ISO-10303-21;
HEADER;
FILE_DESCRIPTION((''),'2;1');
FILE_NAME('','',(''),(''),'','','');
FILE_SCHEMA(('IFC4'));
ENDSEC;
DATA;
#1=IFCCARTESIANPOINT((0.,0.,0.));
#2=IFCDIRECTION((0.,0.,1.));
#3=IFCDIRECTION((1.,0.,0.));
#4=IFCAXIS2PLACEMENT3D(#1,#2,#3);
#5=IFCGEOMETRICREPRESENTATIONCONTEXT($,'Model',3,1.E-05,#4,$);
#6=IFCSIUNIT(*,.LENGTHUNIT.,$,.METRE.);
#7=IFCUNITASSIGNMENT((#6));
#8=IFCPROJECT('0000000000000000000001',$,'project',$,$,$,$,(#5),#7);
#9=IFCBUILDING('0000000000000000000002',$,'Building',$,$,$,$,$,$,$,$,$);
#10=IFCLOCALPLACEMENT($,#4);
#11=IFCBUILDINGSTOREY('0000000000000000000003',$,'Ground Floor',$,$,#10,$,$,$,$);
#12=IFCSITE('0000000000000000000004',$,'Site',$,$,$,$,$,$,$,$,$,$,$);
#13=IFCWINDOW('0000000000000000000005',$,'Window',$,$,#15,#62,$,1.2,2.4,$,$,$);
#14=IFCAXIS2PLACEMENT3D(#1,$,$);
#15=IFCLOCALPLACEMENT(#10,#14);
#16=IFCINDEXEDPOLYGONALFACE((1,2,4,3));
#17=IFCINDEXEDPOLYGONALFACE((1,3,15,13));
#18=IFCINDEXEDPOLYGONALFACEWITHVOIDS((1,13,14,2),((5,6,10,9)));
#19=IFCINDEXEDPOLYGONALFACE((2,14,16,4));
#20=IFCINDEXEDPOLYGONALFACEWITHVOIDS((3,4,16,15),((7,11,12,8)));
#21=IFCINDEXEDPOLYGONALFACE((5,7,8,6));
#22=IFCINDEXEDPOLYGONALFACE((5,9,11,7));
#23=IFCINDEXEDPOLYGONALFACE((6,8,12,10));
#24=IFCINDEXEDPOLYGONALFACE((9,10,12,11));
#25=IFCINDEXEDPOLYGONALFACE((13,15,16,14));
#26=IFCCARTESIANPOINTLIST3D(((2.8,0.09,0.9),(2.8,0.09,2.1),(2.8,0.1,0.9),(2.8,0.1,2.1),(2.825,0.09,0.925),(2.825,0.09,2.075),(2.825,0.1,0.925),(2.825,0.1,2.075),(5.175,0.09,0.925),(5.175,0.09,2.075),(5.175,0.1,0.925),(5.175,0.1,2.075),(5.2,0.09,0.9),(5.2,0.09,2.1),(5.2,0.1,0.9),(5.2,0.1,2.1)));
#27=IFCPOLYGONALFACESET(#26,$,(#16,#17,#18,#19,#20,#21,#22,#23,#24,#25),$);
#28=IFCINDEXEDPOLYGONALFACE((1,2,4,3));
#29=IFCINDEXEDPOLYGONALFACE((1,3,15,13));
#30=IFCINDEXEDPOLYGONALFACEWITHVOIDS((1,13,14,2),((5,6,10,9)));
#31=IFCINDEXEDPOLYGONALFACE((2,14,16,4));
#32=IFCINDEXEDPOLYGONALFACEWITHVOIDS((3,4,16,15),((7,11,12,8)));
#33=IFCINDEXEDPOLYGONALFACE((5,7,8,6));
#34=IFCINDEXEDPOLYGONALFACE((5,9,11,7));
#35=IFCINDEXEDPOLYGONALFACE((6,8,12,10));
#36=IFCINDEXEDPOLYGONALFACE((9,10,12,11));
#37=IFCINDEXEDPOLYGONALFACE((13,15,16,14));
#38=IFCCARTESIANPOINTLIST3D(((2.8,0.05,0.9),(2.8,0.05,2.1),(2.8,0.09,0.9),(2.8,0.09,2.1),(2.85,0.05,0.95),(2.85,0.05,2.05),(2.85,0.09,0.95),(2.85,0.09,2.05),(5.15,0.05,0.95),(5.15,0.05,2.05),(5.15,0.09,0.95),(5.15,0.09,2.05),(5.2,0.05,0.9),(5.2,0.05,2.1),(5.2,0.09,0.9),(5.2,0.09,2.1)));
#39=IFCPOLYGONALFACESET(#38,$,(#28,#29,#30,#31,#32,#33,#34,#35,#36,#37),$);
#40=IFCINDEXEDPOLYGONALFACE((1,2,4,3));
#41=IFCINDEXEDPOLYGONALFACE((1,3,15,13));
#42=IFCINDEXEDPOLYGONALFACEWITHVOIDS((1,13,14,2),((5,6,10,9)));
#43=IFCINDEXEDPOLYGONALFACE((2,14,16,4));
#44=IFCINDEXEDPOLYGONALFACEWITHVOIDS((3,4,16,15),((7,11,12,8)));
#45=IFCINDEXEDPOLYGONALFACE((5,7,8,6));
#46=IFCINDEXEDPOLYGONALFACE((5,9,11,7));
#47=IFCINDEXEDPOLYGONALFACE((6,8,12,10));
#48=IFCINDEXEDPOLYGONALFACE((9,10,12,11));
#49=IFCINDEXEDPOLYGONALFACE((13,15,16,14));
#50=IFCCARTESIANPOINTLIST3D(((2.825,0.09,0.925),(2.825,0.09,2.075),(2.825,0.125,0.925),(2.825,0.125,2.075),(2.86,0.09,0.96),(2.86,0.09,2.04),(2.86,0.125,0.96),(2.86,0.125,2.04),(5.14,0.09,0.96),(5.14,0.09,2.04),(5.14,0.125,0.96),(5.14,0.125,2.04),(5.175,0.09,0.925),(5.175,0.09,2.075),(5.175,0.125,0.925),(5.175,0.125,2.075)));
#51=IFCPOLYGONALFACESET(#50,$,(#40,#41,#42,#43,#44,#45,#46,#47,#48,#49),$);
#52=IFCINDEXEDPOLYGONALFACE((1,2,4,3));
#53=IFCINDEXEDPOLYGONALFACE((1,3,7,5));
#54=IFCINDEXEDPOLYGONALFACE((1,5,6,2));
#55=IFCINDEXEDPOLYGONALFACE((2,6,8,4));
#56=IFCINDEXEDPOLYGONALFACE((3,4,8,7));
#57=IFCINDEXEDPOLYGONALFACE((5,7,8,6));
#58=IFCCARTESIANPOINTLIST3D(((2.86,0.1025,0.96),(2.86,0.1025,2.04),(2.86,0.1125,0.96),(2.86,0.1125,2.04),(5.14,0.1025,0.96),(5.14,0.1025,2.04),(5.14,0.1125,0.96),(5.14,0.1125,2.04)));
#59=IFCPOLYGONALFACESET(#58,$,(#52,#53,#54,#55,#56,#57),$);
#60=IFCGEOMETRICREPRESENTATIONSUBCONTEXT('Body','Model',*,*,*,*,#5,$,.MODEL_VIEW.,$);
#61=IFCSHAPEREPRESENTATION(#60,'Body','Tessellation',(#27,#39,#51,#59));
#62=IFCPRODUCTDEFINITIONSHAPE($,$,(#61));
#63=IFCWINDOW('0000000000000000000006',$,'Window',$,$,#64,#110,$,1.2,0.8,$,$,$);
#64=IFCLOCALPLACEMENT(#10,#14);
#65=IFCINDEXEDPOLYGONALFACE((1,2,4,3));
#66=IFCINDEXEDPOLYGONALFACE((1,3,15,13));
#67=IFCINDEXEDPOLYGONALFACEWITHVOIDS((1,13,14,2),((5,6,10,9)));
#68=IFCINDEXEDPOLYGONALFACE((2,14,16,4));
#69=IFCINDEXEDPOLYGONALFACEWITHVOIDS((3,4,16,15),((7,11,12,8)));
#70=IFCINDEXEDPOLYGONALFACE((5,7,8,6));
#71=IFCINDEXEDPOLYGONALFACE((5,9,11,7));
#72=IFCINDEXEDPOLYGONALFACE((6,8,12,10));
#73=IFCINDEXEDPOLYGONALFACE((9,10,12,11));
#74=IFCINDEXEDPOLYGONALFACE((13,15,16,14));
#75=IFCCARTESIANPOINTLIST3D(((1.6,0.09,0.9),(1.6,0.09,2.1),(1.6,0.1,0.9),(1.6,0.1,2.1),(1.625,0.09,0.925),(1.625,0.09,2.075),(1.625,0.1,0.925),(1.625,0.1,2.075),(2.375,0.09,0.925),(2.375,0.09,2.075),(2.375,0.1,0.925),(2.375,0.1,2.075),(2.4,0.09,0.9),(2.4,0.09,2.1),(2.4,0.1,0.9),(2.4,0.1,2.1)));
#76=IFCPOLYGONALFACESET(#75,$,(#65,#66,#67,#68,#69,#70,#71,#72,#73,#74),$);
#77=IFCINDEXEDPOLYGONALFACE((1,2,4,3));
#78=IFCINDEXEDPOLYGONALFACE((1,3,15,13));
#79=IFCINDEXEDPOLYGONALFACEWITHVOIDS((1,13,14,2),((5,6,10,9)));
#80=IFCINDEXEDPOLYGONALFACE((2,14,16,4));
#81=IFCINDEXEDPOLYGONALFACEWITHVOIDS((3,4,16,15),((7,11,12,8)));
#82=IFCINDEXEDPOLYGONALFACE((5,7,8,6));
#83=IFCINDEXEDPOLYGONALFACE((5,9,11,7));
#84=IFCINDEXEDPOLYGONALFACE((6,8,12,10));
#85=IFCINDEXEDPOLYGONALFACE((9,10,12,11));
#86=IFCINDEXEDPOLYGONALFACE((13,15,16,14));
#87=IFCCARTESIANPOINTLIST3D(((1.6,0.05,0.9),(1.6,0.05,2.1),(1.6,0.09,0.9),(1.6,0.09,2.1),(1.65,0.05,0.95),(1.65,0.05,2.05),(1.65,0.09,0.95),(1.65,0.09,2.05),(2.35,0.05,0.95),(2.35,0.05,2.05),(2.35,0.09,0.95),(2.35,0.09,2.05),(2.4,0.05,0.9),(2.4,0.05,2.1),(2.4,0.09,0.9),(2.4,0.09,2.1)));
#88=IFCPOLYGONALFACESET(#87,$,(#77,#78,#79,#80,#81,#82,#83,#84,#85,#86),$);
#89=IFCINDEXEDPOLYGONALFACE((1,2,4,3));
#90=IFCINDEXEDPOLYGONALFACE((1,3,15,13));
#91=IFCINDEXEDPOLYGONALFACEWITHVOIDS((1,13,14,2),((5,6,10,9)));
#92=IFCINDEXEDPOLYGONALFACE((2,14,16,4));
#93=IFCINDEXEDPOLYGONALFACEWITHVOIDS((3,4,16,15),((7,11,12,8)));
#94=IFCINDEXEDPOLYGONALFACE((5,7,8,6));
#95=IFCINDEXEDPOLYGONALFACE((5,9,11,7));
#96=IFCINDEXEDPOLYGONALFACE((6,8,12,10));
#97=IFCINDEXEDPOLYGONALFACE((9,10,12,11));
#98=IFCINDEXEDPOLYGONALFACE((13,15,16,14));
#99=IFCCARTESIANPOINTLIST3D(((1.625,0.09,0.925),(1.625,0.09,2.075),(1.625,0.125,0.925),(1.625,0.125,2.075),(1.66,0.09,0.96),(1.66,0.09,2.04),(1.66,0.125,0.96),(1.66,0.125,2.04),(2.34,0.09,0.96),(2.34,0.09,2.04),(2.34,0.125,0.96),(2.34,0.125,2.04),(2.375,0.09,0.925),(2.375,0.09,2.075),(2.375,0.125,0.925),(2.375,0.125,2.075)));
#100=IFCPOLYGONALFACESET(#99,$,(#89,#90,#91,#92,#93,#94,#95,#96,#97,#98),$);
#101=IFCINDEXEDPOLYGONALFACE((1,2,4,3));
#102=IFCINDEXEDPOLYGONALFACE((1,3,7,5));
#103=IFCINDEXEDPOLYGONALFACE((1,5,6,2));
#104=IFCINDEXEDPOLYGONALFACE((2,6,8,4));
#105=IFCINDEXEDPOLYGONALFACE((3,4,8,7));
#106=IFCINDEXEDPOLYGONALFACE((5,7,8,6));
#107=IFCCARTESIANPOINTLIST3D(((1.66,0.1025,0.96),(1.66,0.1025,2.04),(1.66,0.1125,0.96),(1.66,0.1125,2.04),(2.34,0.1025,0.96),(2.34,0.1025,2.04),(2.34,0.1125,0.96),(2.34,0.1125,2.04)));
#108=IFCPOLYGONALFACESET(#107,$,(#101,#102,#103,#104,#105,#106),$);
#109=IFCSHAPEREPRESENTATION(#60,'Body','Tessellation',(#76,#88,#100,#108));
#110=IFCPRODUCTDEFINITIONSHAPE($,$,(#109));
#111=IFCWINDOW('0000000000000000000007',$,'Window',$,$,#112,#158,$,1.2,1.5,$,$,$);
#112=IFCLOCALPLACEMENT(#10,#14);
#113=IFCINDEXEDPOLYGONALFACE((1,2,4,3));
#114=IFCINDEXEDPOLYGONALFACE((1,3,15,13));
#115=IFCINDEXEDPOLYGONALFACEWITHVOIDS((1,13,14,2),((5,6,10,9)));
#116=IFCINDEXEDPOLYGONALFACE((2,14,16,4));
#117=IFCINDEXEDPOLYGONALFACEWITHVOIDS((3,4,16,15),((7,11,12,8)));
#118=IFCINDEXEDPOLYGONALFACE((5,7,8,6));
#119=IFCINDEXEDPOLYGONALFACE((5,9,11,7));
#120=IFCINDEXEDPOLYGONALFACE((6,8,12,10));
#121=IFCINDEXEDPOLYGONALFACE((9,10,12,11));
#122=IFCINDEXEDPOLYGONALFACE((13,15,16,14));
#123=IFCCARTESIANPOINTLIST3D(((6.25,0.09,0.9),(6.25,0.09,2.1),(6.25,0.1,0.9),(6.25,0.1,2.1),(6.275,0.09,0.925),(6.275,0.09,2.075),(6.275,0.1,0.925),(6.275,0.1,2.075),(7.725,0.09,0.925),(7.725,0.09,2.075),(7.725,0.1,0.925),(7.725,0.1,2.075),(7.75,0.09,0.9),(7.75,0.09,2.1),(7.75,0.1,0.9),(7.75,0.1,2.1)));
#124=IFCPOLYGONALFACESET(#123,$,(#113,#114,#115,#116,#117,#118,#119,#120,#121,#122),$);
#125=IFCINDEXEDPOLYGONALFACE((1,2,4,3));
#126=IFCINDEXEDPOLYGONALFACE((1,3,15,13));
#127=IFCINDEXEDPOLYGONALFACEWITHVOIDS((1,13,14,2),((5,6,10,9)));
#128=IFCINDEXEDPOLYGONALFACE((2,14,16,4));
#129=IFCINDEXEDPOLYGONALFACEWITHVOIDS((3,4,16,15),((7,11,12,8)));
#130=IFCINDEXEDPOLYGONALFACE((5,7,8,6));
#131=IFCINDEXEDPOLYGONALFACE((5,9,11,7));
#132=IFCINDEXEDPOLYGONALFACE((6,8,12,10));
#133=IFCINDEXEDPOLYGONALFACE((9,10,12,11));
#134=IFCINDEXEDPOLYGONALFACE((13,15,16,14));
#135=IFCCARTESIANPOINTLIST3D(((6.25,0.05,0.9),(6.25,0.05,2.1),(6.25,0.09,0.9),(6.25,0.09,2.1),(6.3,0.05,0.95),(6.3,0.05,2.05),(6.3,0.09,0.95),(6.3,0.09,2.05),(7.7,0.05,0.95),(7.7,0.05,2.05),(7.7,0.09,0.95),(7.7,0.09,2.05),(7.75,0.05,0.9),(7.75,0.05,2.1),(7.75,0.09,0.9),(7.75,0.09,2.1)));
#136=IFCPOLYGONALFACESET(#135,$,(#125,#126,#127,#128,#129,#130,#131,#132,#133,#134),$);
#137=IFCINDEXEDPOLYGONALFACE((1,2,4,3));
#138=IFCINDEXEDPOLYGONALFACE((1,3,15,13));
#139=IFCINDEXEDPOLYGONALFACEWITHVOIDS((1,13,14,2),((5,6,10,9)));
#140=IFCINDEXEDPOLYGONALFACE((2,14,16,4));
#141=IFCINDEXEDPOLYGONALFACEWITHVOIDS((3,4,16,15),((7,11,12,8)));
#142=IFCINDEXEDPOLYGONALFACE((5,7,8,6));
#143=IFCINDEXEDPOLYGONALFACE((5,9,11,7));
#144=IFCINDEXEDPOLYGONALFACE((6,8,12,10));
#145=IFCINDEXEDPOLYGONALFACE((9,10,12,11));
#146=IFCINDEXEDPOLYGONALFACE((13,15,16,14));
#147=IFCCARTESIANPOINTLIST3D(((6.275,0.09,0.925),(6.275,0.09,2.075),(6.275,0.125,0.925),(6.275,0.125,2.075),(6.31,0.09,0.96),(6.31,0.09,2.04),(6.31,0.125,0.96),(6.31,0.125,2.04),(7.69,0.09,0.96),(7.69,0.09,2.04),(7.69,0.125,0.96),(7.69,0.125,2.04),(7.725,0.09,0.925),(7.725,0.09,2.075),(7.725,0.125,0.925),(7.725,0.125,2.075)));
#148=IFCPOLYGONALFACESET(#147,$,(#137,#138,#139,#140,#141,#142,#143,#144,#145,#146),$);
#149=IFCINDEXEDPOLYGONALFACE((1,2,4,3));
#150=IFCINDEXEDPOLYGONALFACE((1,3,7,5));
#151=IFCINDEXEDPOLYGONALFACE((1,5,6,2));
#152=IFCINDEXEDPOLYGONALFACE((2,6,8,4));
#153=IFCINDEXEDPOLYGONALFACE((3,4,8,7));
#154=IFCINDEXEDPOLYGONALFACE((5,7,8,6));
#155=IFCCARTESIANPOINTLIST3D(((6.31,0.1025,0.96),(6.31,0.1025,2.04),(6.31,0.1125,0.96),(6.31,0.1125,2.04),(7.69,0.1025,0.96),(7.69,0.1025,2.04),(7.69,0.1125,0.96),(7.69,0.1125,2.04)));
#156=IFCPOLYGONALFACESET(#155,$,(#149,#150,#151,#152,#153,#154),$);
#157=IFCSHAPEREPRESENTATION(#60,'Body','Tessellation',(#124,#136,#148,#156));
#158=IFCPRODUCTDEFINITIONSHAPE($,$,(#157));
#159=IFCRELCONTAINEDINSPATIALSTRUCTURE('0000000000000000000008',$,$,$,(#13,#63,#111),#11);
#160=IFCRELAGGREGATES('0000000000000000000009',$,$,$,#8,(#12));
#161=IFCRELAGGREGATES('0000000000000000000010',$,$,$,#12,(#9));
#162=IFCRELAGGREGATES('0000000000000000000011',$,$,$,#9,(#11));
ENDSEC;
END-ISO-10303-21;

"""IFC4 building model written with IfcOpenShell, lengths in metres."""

from ifc_helpers import new_model, si_unit, frame, origin_with_axes, place, context, subcontext, project, spatial, line, indexed_curve, outline, extrude, element, save


model = new_model("IFC4")

# Units and contexts
model_context = context("Model", 3, precision=1e-05, world=origin_with_axes())
body_context = subcontext(model_context, "Body", "Model", "MODEL_VIEW")
ifc_project = project(units=[si_unit("LENGTHUNIT", "METRE")], contexts=[model_context])

# Site, building, storey
site = spatial("IfcSite", under=ifc_project, Name="Site")
building = spatial("IfcBuilding", under=site, Name="Building")
storey_placement = place(None, origin_with_axes())
storey = spatial("IfcBuildingStorey", under=building, at=storey_placement, Name="Ground Floor")

# Windows
window_1_placement = place(storey_placement, frame((2.8, 0.0, 0.9), z_axis=(0.0, 0.0, 1.0), x_axis=(1.0, 0.0, 0.0)))
element("IfcWindow", 1, at=window_1_placement, inside=storey, Name="Window", OverallHeight=1.2, OverallWidth=2.4, context=body_context, shape_type="SweptSolid", body=[
    extrude(outline(indexed_curve([(0.0, 0.0), (2.4, 0.0), (2.4, 1.2), (0.0, 1.2)], segments=[line(1, 2, 3, 4, 1)]), holes=[indexed_curve([(0.025, 0.025), (2.375, 0.025), (2.375, 1.175), (0.025, 1.175)], segments=[line(1, 2, 3, 4, 1)])]), frame((0.0, 0.09, 0.0), z_axis=(0.0, -1.0, 0.0), x_axis=(1.0, 0.0, 0.0)), (0.0, 0.0, -1.0), 0.01),
    extrude(outline(indexed_curve([(0.0, 0.0), (2.4, 0.0), (2.4, 1.2), (0.0, 1.2)], segments=[line(1, 2, 3, 4, 1)]), holes=[indexed_curve([(0.05, 0.05), (2.35, 0.05), (2.35, 1.15), (0.05, 1.15)], segments=[line(1, 2, 3, 4, 1)])]), frame((0.0, 0.05, 0.0), z_axis=(0.0, -1.0, 0.0), x_axis=(1.0, 0.0, 0.0)), (0.0, 0.0, -1.0), 0.04),
    extrude(outline(indexed_curve([(0.0, 0.0), (2.35, 0.0), (2.35, 1.15), (0.0, 1.15)], segments=[line(1, 2, 3, 4, 1)]), holes=[indexed_curve([(0.035, 0.035), (2.315, 0.035), (2.315, 1.115), (0.035, 1.115)], segments=[line(1, 2, 3, 4, 1)])]), frame((0.025, 0.09, 0.025), z_axis=(0.0, -1.0, 0.0), x_axis=(1.0, 0.0, 0.0)), (0.0, 0.0, -1.0), 0.035),
    extrude(outline(indexed_curve([(0.035, 0.035), (2.315, 0.035), (2.315, 1.115), (0.035, 1.115)], segments=[line(1, 2, 3, 4, 1)])), frame((0.025, 0.1025, 0.025), z_axis=(0.0, -1.0, 0.0), x_axis=(1.0, 0.0, 0.0)), (0.0, 0.0, -1.0), 0.01),
])
window_2_placement = place(storey_placement, frame((1.6, 0.0, 0.9), z_axis=(0.0, 0.0, 1.0), x_axis=(1.0, 0.0, 0.0)))
element("IfcWindow", 2, at=window_2_placement, inside=storey, Name="Window", OverallHeight=1.2, OverallWidth=0.8, context=body_context, shape_type="SweptSolid", body=[
    extrude(outline(indexed_curve([(0.0, 0.0), (0.8, 0.0), (0.8, 1.2), (0.0, 1.2)], segments=[line(1, 2, 3, 4, 1)]), holes=[indexed_curve([(0.025, 0.025), (0.775, 0.025), (0.775, 1.175), (0.025, 1.175)], segments=[line(1, 2, 3, 4, 1)])]), frame((0.0, 0.09, 0.0), z_axis=(0.0, -1.0, 0.0), x_axis=(1.0, 0.0, 0.0)), (0.0, 0.0, -1.0), 0.01),
    extrude(outline(indexed_curve([(0.0, 0.0), (0.8, 0.0), (0.8, 1.2), (0.0, 1.2)], segments=[line(1, 2, 3, 4, 1)]), holes=[indexed_curve([(0.05, 0.05), (0.75, 0.05), (0.75, 1.15), (0.05, 1.15)], segments=[line(1, 2, 3, 4, 1)])]), frame((0.0, 0.05, 0.0), z_axis=(0.0, -1.0, 0.0), x_axis=(1.0, 0.0, 0.0)), (0.0, 0.0, -1.0), 0.04),
    extrude(outline(indexed_curve([(0.0, 0.0), (0.75, 0.0), (0.75, 1.15), (0.0, 1.15)], segments=[line(1, 2, 3, 4, 1)]), holes=[indexed_curve([(0.035, 0.035), (0.715, 0.035), (0.715, 1.115), (0.035, 1.115)], segments=[line(1, 2, 3, 4, 1)])]), frame((0.025, 0.09, 0.025), z_axis=(0.0, -1.0, 0.0), x_axis=(1.0, 0.0, 0.0)), (0.0, 0.0, -1.0), 0.035),
    extrude(outline(indexed_curve([(0.035, 0.035), (0.715, 0.035), (0.715, 1.115), (0.035, 1.115)], segments=[line(1, 2, 3, 4, 1)])), frame((0.025, 0.1025, 0.025), z_axis=(0.0, -1.0, 0.0), x_axis=(1.0, 0.0, 0.0)), (0.0, 0.0, -1.0), 0.01),
])
window_3_placement = place(storey_placement, frame((6.25, 0.0, 0.9), z_axis=(0.0, 0.0, 1.0), x_axis=(1.0, 0.0, 0.0)))
element("IfcWindow", 3, at=window_3_placement, inside=storey, Name="Window", OverallHeight=1.2, OverallWidth=1.5, context=body_context, shape_type="SweptSolid", body=[
    extrude(outline(indexed_curve([(0.0, 0.0), (1.5, 0.0), (1.5, 1.2), (0.0, 1.2)], segments=[line(1, 2, 3, 4, 1)]), holes=[indexed_curve([(0.025, 0.025), (1.475, 0.025), (1.475, 1.175), (0.025, 1.175)], segments=[line(1, 2, 3, 4, 1)])]), frame((0.0, 0.09, 0.0), z_axis=(0.0, -1.0, 0.0), x_axis=(1.0, 0.0, 0.0)), (0.0, 0.0, -1.0), 0.01),
    extrude(outline(indexed_curve([(0.0, 0.0), (1.5, 0.0), (1.5, 1.2), (0.0, 1.2)], segments=[line(1, 2, 3, 4, 1)]), holes=[indexed_curve([(0.05, 0.05), (1.45, 0.05), (1.45, 1.15), (0.05, 1.15)], segments=[line(1, 2, 3, 4, 1)])]), frame((0.0, 0.05, 0.0), z_axis=(0.0, -1.0, 0.0), x_axis=(1.0, 0.0, 0.0)), (0.0, 0.0, -1.0), 0.04),
    extrude(outline(indexed_curve([(0.0, 0.0), (1.45, 0.0), (1.45, 1.15), (0.0, 1.15)], segments=[line(1, 2, 3, 4, 1)]), holes=[indexed_curve([(0.035, 0.035), (1.415, 0.035), (1.415, 1.115), (0.035, 1.115)], segments=[line(1, 2, 3, 4, 1)])]), frame((0.025, 0.09, 0.025), z_axis=(0.0, -1.0, 0.0), x_axis=(1.0, 0.0, 0.0)), (0.0, 0.0, -1.0), 0.035),
    extrude(outline(indexed_curve([(0.035, 0.035), (1.415, 0.035), (1.415, 1.115), (0.035, 1.115)], segments=[line(1, 2, 3, 4, 1)])), frame((0.025, 0.1025, 0.025), z_axis=(0.0, -1.0, 0.0), x_axis=(1.0, 0.0, 0.0)), (0.0, 0.0, -1.0), 0.01),
])

save(model, "model.ifc")
